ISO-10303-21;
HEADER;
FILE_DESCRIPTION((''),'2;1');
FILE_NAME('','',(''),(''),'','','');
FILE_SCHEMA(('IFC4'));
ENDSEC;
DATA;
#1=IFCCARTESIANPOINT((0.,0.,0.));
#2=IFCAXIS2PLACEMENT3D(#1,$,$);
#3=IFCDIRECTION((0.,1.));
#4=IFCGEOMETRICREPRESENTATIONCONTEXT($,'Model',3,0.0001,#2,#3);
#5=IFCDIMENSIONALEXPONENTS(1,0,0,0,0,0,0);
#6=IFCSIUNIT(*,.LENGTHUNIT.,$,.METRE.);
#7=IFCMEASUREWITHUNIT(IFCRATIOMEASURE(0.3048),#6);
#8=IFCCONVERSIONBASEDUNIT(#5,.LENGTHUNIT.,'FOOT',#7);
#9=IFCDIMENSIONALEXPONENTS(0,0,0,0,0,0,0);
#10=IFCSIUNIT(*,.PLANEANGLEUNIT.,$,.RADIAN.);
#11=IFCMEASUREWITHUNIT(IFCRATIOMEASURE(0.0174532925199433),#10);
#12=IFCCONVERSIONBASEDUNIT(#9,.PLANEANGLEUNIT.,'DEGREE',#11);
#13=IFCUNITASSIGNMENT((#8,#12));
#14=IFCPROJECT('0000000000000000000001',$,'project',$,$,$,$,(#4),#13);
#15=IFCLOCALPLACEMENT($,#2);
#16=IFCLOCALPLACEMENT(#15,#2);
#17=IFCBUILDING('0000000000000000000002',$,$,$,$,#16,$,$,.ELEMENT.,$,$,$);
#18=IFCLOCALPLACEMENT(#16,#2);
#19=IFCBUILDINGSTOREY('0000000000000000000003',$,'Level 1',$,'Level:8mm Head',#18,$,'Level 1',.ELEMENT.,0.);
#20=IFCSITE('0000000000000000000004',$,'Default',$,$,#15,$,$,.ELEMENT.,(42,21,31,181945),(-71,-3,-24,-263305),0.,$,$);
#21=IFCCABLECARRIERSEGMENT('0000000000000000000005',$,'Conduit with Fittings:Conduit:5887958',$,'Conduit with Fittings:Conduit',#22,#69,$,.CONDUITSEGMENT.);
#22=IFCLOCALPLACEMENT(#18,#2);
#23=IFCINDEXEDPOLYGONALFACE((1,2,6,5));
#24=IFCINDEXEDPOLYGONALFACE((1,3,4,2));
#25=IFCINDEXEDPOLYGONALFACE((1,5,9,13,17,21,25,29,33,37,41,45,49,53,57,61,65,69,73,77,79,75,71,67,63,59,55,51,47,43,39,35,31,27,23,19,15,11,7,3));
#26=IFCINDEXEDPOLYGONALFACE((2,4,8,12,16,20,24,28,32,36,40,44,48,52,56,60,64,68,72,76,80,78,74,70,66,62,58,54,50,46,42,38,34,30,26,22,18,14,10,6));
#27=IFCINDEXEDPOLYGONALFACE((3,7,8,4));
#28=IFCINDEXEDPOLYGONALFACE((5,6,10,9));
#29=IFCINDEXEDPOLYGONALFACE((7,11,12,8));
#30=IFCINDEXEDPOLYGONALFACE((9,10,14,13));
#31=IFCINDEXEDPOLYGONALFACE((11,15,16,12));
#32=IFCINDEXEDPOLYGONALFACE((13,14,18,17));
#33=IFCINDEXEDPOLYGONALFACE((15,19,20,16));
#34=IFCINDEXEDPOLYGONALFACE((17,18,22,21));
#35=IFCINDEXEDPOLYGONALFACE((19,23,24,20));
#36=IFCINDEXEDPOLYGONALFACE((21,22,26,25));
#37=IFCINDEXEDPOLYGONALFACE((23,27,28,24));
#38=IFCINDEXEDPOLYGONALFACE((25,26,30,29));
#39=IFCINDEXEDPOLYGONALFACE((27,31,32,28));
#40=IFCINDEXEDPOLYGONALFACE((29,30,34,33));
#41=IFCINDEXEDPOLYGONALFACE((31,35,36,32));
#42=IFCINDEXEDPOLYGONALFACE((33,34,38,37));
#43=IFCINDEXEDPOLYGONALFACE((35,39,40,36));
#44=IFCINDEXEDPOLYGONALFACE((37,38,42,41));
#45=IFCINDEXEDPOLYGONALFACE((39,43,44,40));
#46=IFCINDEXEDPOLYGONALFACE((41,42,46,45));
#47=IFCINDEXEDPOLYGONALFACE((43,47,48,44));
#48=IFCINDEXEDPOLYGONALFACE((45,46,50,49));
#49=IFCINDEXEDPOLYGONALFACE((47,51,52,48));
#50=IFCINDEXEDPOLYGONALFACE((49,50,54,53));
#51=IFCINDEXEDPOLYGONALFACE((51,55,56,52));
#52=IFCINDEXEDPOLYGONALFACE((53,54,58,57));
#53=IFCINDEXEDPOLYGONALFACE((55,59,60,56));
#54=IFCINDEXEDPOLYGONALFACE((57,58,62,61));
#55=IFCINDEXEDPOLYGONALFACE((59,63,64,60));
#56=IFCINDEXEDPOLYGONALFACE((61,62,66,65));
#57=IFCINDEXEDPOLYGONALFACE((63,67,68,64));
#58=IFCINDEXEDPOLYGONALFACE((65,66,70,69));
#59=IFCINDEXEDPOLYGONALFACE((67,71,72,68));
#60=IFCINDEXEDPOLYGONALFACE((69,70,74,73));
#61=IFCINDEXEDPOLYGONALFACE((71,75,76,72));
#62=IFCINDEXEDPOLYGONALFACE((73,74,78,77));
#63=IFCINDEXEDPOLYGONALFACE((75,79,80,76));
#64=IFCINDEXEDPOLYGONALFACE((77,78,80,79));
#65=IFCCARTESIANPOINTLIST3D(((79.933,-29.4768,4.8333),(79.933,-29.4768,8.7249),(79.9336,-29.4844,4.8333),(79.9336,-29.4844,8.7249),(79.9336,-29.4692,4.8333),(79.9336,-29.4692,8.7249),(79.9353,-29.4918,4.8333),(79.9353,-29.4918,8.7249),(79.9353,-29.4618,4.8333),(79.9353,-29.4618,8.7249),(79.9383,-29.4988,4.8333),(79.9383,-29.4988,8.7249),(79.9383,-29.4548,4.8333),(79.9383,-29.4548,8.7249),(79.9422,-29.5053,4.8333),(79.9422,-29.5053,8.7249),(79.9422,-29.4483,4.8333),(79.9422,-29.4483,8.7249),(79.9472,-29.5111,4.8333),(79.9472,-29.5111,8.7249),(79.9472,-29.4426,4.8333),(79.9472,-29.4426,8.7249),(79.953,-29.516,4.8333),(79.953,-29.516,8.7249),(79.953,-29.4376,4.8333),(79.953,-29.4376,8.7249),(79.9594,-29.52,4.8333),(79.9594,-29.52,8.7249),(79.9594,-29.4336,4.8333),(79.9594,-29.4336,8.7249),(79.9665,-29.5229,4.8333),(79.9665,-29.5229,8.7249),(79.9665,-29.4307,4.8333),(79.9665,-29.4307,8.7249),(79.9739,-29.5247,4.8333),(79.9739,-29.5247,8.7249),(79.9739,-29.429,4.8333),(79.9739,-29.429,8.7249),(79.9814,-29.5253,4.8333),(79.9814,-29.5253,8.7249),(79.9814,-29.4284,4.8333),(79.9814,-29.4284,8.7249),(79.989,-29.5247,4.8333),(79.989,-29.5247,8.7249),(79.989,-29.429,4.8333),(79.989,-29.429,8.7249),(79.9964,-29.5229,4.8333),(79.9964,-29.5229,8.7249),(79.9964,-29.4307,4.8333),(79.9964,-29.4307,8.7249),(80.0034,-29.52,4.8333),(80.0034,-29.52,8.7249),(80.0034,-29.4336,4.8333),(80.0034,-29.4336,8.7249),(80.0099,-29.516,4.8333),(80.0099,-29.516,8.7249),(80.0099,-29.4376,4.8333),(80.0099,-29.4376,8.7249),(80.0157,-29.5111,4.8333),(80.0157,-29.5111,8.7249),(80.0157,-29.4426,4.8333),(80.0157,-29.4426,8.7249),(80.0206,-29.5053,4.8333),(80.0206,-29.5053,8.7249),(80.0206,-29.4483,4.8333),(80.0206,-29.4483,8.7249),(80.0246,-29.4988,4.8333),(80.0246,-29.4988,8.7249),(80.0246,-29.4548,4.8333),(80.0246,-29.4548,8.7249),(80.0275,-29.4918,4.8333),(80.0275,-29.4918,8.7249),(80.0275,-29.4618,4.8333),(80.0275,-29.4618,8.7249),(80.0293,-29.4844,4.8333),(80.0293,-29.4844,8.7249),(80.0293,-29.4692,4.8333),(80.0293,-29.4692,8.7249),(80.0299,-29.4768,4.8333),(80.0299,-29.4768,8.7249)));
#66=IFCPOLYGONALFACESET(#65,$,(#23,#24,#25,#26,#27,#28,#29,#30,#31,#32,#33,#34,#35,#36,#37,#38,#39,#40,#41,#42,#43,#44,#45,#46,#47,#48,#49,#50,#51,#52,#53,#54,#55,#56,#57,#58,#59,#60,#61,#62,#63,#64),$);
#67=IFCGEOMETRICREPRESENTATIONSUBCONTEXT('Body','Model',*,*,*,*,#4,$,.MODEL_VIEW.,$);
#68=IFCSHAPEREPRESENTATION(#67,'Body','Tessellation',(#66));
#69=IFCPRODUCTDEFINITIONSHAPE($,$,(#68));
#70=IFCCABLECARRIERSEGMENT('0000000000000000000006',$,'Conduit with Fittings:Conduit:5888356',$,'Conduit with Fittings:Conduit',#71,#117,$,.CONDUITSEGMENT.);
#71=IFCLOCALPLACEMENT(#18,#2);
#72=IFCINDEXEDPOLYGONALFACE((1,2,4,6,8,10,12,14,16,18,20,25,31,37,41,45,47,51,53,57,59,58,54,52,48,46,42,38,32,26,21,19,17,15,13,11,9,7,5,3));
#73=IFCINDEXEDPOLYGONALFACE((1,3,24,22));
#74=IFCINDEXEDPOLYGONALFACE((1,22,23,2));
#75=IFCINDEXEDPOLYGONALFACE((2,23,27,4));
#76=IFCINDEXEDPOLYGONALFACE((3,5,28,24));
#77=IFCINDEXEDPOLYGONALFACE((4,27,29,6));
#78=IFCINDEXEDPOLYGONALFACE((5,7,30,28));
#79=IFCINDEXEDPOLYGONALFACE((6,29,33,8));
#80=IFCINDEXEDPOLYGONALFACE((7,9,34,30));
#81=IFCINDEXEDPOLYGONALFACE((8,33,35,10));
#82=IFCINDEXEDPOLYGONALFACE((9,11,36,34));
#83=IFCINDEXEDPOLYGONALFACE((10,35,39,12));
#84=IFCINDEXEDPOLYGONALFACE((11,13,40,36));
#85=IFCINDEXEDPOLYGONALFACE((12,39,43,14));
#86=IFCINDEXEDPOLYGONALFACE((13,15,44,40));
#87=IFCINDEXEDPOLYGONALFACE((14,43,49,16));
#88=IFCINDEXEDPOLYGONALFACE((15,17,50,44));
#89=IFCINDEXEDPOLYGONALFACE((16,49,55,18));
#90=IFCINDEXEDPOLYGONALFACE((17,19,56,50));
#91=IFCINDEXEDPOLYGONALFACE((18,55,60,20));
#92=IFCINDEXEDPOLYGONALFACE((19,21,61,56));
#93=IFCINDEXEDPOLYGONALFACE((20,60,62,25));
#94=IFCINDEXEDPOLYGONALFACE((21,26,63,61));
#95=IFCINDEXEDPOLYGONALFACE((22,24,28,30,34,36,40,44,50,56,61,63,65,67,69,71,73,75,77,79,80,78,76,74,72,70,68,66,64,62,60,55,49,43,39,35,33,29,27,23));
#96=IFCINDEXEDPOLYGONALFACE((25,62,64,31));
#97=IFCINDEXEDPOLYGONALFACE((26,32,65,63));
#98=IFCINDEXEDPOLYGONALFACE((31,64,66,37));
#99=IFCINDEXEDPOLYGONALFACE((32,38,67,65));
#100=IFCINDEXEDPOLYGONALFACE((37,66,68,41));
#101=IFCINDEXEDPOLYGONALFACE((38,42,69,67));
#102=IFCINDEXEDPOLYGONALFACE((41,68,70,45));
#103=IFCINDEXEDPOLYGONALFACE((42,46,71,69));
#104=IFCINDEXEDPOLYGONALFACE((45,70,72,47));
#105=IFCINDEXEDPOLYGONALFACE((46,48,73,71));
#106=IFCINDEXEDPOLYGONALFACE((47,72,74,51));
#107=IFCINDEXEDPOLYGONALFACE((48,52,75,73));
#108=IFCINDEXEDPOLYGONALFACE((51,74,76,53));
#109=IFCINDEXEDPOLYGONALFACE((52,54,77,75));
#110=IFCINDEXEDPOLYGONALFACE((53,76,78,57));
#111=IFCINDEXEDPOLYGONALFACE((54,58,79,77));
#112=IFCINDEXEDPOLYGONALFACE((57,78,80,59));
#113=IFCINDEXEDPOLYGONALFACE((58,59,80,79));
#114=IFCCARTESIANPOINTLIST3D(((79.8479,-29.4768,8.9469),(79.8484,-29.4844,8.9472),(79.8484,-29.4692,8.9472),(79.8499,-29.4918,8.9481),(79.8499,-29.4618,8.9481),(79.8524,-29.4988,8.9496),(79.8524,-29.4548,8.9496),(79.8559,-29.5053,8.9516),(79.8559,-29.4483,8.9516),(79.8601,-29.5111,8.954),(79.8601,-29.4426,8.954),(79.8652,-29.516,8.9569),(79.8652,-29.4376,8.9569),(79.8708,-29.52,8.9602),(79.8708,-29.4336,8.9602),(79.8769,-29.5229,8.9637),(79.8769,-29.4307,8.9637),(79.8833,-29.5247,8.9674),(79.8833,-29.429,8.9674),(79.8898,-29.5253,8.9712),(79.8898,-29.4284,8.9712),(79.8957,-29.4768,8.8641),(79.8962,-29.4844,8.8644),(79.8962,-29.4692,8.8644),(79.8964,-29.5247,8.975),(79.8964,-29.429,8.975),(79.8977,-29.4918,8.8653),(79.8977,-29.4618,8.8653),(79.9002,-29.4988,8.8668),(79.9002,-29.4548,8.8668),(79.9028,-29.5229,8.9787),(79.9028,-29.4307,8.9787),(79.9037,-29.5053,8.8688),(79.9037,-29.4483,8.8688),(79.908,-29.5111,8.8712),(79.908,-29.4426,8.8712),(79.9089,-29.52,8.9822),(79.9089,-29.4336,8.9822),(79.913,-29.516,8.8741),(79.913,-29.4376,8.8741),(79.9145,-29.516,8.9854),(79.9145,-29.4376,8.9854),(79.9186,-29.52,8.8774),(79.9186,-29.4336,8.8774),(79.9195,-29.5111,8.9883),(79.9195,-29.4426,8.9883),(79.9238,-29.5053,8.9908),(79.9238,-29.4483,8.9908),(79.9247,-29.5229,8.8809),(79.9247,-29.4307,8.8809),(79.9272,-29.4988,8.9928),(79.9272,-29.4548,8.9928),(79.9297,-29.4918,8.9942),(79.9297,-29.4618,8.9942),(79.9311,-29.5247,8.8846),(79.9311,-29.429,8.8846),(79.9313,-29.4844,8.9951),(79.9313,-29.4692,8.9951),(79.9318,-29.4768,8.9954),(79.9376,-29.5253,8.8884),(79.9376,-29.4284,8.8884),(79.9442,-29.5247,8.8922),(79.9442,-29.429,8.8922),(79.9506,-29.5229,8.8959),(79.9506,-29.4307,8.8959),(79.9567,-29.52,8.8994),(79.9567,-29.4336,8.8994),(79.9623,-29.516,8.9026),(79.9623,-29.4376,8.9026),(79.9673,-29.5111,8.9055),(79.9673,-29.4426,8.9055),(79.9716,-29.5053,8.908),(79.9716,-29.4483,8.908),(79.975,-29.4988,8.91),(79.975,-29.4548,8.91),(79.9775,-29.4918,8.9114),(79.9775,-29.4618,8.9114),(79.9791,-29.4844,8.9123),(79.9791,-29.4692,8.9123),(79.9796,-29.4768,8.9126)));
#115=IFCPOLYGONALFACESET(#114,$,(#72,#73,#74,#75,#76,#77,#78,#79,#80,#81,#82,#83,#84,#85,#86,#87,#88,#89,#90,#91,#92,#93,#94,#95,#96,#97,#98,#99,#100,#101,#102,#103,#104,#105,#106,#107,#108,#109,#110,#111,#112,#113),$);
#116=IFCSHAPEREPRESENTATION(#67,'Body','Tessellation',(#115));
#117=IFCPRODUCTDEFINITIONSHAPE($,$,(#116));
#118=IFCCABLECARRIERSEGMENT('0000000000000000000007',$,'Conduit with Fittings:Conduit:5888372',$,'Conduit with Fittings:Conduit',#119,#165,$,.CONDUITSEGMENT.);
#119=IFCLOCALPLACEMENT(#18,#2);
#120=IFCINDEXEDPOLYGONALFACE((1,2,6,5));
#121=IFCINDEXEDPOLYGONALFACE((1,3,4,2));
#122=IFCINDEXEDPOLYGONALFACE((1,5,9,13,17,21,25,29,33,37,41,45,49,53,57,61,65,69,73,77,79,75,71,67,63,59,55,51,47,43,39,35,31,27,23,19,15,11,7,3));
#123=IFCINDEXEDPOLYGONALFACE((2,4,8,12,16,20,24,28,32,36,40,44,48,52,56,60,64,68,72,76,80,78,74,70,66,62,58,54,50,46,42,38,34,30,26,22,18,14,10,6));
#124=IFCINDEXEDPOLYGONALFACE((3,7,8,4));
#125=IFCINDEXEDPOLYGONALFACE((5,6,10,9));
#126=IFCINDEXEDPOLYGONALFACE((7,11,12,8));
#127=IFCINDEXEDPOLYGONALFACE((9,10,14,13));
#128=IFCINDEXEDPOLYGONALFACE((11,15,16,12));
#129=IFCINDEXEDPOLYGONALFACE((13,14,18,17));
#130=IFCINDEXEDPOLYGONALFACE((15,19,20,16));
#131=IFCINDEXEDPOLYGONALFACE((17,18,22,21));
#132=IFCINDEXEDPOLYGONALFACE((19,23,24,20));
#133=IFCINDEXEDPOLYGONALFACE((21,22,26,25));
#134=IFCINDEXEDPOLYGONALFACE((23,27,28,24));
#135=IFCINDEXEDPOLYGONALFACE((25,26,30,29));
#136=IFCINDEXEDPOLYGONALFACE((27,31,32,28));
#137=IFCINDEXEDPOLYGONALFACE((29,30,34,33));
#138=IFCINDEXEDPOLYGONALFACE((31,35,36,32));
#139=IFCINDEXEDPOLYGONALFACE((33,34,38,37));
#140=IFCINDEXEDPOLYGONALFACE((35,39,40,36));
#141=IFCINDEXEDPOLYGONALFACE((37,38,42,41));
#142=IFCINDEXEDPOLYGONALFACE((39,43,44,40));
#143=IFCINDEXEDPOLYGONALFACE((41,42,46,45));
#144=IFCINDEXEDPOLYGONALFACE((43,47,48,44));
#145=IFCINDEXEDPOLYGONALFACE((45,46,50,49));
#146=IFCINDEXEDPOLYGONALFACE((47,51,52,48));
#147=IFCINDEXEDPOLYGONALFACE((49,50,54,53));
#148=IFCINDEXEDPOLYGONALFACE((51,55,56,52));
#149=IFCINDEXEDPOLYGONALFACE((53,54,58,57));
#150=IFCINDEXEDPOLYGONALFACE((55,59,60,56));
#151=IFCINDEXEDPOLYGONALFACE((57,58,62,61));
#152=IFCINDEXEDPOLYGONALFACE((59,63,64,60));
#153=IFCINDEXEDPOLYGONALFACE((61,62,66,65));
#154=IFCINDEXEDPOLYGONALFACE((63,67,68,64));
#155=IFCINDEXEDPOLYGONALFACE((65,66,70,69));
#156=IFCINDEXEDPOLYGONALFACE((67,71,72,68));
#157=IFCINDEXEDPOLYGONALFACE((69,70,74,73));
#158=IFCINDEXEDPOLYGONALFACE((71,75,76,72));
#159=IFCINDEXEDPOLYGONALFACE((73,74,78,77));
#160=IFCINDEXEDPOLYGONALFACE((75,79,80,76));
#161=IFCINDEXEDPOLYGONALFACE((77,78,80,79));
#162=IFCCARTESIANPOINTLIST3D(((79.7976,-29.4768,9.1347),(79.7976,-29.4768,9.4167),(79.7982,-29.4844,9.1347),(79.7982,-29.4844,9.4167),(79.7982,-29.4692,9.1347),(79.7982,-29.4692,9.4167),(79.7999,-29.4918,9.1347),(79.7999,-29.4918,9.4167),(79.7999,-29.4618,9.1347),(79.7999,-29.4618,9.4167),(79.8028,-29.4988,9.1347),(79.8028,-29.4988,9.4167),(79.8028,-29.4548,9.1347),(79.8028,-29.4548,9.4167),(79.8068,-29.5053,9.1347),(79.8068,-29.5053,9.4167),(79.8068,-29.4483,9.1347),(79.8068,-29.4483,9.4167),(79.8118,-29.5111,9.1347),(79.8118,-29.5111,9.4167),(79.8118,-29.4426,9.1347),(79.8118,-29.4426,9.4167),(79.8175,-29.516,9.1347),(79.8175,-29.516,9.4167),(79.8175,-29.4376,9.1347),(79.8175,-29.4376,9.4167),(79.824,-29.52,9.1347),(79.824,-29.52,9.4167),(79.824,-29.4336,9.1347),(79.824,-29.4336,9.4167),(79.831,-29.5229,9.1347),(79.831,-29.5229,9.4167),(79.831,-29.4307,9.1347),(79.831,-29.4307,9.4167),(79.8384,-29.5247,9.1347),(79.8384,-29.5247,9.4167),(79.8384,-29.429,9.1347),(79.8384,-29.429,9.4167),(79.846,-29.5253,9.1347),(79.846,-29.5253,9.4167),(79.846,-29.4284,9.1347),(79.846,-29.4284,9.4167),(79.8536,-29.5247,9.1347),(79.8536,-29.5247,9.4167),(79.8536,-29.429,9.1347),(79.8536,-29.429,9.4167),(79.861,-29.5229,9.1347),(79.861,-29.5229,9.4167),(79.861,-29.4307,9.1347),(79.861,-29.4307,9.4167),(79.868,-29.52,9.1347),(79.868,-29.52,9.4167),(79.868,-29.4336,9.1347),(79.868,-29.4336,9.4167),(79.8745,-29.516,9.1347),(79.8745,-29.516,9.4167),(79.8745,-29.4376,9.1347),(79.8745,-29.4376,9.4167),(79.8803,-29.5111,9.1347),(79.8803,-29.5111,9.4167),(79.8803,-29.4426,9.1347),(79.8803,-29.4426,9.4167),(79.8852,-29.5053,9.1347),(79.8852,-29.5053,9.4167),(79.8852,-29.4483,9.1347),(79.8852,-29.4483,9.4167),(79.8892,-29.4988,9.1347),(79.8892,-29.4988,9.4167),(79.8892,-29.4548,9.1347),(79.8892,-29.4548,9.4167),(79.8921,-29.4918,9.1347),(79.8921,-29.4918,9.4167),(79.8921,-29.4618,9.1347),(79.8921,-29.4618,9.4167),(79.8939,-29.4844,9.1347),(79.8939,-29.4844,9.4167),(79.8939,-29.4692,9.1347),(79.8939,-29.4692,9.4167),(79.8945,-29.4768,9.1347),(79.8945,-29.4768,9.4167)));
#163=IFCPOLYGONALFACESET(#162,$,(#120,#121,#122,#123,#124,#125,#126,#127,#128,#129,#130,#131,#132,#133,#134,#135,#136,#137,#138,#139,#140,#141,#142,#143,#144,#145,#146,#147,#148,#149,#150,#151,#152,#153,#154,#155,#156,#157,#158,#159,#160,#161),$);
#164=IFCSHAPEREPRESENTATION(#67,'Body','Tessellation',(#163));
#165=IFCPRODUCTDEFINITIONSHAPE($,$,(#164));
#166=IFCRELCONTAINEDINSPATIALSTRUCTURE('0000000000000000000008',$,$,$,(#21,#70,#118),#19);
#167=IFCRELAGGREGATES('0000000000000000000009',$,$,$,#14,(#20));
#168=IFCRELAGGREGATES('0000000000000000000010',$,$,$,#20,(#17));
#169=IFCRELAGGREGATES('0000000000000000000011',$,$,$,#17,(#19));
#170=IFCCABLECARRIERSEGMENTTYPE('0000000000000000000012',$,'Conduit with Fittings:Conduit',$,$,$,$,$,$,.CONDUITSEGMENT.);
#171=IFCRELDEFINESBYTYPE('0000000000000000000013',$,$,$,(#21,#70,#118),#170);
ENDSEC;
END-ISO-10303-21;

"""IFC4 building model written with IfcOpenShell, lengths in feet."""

from ifc_helpers import new_model, entity, si_unit, converted_unit, direction, frame, origin, place, context, subcontext, project, spatial, indexed_curve, outline, extrude, type_object, element, save


model = new_model("IFC4")

# Units and contexts
model_context = context("Model", 3, precision=0.0001, world=origin(), true_north=direction((0.0, 1.0)))
body_context = subcontext(model_context, "Body", "Model", "MODEL_VIEW")
ifc_project = project(units=[converted_unit("LENGTHUNIT", "FOOT", entity("IfcRatioMeasure", 0.3048), si_unit("LENGTHUNIT", "METRE"), dimensions=[1, 0, 0, 0, 0, 0, 0]), converted_unit("PLANEANGLEUNIT", "DEGREE", entity("IfcRatioMeasure", 0.0174532925199433), si_unit("PLANEANGLEUNIT", "RADIAN"), dimensions=[0, 0, 0, 0, 0, 0, 0])], contexts=[model_context])

# Site, building, storey
site_placement = place(None, origin())
site = spatial("IfcSite", under=ifc_project, at=site_placement, Name="Default", CompositionType="ELEMENT", RefLatitude=(42, 21, 31, 181945), RefLongitude=(-71, -3, -24, -263305), RefElevation=0.0)
building_placement = place(site_placement, origin())
building = spatial("IfcBuilding", under=site, at=building_placement, CompositionType="ELEMENT")
storey_placement = place(building_placement, origin())
storey = spatial("IfcBuildingStorey", under=building, at=storey_placement, Name="Level 1", ObjectType="Level:8mm Head", LongName="Level 1", CompositionType="ELEMENT", Elevation=0.0)

# Cable carrier segments
cable_carrier_segment_type = type_object("IfcCableCarrierSegmentType", Name="Conduit with Fittings:Conduit", PredefinedType="CONDUITSEGMENT")
cable_carrier_segment_1_placement = place(storey_placement, origin())
element("IfcCableCarrierSegment", 1, at=cable_carrier_segment_1_placement, inside=storey, type_object=cable_carrier_segment_type, Name="Conduit with Fittings:Conduit:5887958", ObjectType="Conduit with Fittings:Conduit", PredefinedType="CONDUITSEGMENT", context=body_context, shape_type="SweptSolid", body=[
    extrude(outline(indexed_curve([(0.0485, 0.0), (0.0479, 0.0076), (0.0461, 0.015), (0.0432, 0.022), (0.0392, 0.0285), (0.0343, 0.0343), (0.0285, 0.0392), (0.022, 0.0432), (0.015, 0.0461), (0.0076, 0.0479), (0.0, 0.0485), (-0.0076, 0.0479), (-0.015, 0.0461), (-0.022, 0.0432), (-0.0285, 0.0392), (-0.0343, 0.0343), (-0.0392, 0.0285), (-0.0432, 0.022), (-0.0461, 0.015), (-0.0479, 0.0076), (-0.0485, 0.0), (-0.0479, -0.0076), (-0.0461, -0.015), (-0.0432, -0.022), (-0.0392, -0.0285), (-0.0343, -0.0343), (-0.0285, -0.0392), (-0.022, -0.0432), (-0.015, -0.0461), (-0.0076, -0.0479), (0.0, -0.0485), (0.0076, -0.0479), (0.015, -0.0461), (0.022, -0.0432), (0.0285, -0.0392), (0.0343, -0.0343), (0.0392, -0.0285), (0.0432, -0.022), (0.0461, -0.015), (0.0479, -0.0076), (0.0485, 0.0)], self_intersect=False)), frame((79.9814, -29.4768, 4.8333), z_axis=(0.0, 0.0, 1.0), x_axis=(-1.0, 0.0, 0.0)), (0.0, 0.0, 1.0), 3.8916),
])
cable_carrier_segment_2_placement = place(storey_placement, origin())
element("IfcCableCarrierSegment", 2, at=cable_carrier_segment_2_placement, inside=storey, type_object=cable_carrier_segment_type, Name="Conduit with Fittings:Conduit:5888356", ObjectType="Conduit with Fittings:Conduit", PredefinedType="CONDUITSEGMENT", context=body_context, shape_type="SweptSolid", body=[
    extrude(outline(indexed_curve([(0.0485, 0.0), (0.0479, 0.0076), (0.0461, 0.015), (0.0432, 0.022), (0.0392, 0.0285), (0.0343, 0.0343), (0.0285, 0.0392), (0.022, 0.0432), (0.015, 0.0461), (0.0076, 0.0479), (0.0, 0.0485), (-0.0076, 0.0479), (-0.015, 0.0461), (-0.022, 0.0432), (-0.0285, 0.0392), (-0.0343, 0.0343), (-0.0392, 0.0285), (-0.0432, 0.022), (-0.0461, 0.015), (-0.0479, 0.0076), (-0.0485, 0.0), (-0.0479, -0.0076), (-0.0461, -0.015), (-0.0432, -0.022), (-0.0392, -0.0285), (-0.0343, -0.0343), (-0.0285, -0.0392), (-0.022, -0.0432), (-0.015, -0.0461), (-0.0076, -0.0479), (0.0, -0.0485), (0.0076, -0.0479), (0.015, -0.0461), (0.022, -0.0432), (0.0285, -0.0392), (0.0343, -0.0343), (0.0392, -0.0285), (0.0432, -0.022), (0.0461, -0.015), (0.0479, -0.0076), (0.0485, 0.0)], self_intersect=False)), frame((79.9376, -29.4768, 8.8884), z_axis=(-0.5, 0.0, 0.866025), x_axis=(0.0, 1.0, 0.0)), (0.0, 0.0, 1.0), 0.0956),
])
cable_carrier_segment_3_placement = place(storey_placement, origin())
element("IfcCableCarrierSegment", 3, at=cable_carrier_segment_3_placement, inside=storey, type_object=cable_carrier_segment_type, Name="Conduit with Fittings:Conduit:5888372", ObjectType="Conduit with Fittings:Conduit", PredefinedType="CONDUITSEGMENT", context=body_context, shape_type="SweptSolid", body=[
    extrude(outline(indexed_curve([(0.0485, 0.0), (0.0479, 0.0076), (0.0461, 0.015), (0.0432, 0.022), (0.0392, 0.0285), (0.0343, 0.0343), (0.0285, 0.0392), (0.022, 0.0432), (0.015, 0.0461), (0.0076, 0.0479), (0.0, 0.0485), (-0.0076, 0.0479), (-0.015, 0.0461), (-0.022, 0.0432), (-0.0285, 0.0392), (-0.0343, 0.0343), (-0.0392, 0.0285), (-0.0432, 0.022), (-0.0461, 0.015), (-0.0479, 0.0076), (-0.0485, 0.0), (-0.0479, -0.0076), (-0.0461, -0.015), (-0.0432, -0.022), (-0.0392, -0.0285), (-0.0343, -0.0343), (-0.0285, -0.0392), (-0.022, -0.0432), (-0.015, -0.0461), (-0.0076, -0.0479), (0.0, -0.0485), (0.0076, -0.0479), (0.015, -0.0461), (0.022, -0.0432), (0.0285, -0.0392), (0.0343, -0.0343), (0.0392, -0.0285), (0.0432, -0.022), (0.0461, -0.015), (0.0479, -0.0076), (0.0485, 0.0)], self_intersect=False)), frame((79.846, -29.4768, 9.1347), z_axis=(0.0, 0.0, 1.0), x_axis=(-1.0, 0.0, 0.0)), (0.0, 0.0, 1.0), 0.282),
])

save(model, "model.ifc")
